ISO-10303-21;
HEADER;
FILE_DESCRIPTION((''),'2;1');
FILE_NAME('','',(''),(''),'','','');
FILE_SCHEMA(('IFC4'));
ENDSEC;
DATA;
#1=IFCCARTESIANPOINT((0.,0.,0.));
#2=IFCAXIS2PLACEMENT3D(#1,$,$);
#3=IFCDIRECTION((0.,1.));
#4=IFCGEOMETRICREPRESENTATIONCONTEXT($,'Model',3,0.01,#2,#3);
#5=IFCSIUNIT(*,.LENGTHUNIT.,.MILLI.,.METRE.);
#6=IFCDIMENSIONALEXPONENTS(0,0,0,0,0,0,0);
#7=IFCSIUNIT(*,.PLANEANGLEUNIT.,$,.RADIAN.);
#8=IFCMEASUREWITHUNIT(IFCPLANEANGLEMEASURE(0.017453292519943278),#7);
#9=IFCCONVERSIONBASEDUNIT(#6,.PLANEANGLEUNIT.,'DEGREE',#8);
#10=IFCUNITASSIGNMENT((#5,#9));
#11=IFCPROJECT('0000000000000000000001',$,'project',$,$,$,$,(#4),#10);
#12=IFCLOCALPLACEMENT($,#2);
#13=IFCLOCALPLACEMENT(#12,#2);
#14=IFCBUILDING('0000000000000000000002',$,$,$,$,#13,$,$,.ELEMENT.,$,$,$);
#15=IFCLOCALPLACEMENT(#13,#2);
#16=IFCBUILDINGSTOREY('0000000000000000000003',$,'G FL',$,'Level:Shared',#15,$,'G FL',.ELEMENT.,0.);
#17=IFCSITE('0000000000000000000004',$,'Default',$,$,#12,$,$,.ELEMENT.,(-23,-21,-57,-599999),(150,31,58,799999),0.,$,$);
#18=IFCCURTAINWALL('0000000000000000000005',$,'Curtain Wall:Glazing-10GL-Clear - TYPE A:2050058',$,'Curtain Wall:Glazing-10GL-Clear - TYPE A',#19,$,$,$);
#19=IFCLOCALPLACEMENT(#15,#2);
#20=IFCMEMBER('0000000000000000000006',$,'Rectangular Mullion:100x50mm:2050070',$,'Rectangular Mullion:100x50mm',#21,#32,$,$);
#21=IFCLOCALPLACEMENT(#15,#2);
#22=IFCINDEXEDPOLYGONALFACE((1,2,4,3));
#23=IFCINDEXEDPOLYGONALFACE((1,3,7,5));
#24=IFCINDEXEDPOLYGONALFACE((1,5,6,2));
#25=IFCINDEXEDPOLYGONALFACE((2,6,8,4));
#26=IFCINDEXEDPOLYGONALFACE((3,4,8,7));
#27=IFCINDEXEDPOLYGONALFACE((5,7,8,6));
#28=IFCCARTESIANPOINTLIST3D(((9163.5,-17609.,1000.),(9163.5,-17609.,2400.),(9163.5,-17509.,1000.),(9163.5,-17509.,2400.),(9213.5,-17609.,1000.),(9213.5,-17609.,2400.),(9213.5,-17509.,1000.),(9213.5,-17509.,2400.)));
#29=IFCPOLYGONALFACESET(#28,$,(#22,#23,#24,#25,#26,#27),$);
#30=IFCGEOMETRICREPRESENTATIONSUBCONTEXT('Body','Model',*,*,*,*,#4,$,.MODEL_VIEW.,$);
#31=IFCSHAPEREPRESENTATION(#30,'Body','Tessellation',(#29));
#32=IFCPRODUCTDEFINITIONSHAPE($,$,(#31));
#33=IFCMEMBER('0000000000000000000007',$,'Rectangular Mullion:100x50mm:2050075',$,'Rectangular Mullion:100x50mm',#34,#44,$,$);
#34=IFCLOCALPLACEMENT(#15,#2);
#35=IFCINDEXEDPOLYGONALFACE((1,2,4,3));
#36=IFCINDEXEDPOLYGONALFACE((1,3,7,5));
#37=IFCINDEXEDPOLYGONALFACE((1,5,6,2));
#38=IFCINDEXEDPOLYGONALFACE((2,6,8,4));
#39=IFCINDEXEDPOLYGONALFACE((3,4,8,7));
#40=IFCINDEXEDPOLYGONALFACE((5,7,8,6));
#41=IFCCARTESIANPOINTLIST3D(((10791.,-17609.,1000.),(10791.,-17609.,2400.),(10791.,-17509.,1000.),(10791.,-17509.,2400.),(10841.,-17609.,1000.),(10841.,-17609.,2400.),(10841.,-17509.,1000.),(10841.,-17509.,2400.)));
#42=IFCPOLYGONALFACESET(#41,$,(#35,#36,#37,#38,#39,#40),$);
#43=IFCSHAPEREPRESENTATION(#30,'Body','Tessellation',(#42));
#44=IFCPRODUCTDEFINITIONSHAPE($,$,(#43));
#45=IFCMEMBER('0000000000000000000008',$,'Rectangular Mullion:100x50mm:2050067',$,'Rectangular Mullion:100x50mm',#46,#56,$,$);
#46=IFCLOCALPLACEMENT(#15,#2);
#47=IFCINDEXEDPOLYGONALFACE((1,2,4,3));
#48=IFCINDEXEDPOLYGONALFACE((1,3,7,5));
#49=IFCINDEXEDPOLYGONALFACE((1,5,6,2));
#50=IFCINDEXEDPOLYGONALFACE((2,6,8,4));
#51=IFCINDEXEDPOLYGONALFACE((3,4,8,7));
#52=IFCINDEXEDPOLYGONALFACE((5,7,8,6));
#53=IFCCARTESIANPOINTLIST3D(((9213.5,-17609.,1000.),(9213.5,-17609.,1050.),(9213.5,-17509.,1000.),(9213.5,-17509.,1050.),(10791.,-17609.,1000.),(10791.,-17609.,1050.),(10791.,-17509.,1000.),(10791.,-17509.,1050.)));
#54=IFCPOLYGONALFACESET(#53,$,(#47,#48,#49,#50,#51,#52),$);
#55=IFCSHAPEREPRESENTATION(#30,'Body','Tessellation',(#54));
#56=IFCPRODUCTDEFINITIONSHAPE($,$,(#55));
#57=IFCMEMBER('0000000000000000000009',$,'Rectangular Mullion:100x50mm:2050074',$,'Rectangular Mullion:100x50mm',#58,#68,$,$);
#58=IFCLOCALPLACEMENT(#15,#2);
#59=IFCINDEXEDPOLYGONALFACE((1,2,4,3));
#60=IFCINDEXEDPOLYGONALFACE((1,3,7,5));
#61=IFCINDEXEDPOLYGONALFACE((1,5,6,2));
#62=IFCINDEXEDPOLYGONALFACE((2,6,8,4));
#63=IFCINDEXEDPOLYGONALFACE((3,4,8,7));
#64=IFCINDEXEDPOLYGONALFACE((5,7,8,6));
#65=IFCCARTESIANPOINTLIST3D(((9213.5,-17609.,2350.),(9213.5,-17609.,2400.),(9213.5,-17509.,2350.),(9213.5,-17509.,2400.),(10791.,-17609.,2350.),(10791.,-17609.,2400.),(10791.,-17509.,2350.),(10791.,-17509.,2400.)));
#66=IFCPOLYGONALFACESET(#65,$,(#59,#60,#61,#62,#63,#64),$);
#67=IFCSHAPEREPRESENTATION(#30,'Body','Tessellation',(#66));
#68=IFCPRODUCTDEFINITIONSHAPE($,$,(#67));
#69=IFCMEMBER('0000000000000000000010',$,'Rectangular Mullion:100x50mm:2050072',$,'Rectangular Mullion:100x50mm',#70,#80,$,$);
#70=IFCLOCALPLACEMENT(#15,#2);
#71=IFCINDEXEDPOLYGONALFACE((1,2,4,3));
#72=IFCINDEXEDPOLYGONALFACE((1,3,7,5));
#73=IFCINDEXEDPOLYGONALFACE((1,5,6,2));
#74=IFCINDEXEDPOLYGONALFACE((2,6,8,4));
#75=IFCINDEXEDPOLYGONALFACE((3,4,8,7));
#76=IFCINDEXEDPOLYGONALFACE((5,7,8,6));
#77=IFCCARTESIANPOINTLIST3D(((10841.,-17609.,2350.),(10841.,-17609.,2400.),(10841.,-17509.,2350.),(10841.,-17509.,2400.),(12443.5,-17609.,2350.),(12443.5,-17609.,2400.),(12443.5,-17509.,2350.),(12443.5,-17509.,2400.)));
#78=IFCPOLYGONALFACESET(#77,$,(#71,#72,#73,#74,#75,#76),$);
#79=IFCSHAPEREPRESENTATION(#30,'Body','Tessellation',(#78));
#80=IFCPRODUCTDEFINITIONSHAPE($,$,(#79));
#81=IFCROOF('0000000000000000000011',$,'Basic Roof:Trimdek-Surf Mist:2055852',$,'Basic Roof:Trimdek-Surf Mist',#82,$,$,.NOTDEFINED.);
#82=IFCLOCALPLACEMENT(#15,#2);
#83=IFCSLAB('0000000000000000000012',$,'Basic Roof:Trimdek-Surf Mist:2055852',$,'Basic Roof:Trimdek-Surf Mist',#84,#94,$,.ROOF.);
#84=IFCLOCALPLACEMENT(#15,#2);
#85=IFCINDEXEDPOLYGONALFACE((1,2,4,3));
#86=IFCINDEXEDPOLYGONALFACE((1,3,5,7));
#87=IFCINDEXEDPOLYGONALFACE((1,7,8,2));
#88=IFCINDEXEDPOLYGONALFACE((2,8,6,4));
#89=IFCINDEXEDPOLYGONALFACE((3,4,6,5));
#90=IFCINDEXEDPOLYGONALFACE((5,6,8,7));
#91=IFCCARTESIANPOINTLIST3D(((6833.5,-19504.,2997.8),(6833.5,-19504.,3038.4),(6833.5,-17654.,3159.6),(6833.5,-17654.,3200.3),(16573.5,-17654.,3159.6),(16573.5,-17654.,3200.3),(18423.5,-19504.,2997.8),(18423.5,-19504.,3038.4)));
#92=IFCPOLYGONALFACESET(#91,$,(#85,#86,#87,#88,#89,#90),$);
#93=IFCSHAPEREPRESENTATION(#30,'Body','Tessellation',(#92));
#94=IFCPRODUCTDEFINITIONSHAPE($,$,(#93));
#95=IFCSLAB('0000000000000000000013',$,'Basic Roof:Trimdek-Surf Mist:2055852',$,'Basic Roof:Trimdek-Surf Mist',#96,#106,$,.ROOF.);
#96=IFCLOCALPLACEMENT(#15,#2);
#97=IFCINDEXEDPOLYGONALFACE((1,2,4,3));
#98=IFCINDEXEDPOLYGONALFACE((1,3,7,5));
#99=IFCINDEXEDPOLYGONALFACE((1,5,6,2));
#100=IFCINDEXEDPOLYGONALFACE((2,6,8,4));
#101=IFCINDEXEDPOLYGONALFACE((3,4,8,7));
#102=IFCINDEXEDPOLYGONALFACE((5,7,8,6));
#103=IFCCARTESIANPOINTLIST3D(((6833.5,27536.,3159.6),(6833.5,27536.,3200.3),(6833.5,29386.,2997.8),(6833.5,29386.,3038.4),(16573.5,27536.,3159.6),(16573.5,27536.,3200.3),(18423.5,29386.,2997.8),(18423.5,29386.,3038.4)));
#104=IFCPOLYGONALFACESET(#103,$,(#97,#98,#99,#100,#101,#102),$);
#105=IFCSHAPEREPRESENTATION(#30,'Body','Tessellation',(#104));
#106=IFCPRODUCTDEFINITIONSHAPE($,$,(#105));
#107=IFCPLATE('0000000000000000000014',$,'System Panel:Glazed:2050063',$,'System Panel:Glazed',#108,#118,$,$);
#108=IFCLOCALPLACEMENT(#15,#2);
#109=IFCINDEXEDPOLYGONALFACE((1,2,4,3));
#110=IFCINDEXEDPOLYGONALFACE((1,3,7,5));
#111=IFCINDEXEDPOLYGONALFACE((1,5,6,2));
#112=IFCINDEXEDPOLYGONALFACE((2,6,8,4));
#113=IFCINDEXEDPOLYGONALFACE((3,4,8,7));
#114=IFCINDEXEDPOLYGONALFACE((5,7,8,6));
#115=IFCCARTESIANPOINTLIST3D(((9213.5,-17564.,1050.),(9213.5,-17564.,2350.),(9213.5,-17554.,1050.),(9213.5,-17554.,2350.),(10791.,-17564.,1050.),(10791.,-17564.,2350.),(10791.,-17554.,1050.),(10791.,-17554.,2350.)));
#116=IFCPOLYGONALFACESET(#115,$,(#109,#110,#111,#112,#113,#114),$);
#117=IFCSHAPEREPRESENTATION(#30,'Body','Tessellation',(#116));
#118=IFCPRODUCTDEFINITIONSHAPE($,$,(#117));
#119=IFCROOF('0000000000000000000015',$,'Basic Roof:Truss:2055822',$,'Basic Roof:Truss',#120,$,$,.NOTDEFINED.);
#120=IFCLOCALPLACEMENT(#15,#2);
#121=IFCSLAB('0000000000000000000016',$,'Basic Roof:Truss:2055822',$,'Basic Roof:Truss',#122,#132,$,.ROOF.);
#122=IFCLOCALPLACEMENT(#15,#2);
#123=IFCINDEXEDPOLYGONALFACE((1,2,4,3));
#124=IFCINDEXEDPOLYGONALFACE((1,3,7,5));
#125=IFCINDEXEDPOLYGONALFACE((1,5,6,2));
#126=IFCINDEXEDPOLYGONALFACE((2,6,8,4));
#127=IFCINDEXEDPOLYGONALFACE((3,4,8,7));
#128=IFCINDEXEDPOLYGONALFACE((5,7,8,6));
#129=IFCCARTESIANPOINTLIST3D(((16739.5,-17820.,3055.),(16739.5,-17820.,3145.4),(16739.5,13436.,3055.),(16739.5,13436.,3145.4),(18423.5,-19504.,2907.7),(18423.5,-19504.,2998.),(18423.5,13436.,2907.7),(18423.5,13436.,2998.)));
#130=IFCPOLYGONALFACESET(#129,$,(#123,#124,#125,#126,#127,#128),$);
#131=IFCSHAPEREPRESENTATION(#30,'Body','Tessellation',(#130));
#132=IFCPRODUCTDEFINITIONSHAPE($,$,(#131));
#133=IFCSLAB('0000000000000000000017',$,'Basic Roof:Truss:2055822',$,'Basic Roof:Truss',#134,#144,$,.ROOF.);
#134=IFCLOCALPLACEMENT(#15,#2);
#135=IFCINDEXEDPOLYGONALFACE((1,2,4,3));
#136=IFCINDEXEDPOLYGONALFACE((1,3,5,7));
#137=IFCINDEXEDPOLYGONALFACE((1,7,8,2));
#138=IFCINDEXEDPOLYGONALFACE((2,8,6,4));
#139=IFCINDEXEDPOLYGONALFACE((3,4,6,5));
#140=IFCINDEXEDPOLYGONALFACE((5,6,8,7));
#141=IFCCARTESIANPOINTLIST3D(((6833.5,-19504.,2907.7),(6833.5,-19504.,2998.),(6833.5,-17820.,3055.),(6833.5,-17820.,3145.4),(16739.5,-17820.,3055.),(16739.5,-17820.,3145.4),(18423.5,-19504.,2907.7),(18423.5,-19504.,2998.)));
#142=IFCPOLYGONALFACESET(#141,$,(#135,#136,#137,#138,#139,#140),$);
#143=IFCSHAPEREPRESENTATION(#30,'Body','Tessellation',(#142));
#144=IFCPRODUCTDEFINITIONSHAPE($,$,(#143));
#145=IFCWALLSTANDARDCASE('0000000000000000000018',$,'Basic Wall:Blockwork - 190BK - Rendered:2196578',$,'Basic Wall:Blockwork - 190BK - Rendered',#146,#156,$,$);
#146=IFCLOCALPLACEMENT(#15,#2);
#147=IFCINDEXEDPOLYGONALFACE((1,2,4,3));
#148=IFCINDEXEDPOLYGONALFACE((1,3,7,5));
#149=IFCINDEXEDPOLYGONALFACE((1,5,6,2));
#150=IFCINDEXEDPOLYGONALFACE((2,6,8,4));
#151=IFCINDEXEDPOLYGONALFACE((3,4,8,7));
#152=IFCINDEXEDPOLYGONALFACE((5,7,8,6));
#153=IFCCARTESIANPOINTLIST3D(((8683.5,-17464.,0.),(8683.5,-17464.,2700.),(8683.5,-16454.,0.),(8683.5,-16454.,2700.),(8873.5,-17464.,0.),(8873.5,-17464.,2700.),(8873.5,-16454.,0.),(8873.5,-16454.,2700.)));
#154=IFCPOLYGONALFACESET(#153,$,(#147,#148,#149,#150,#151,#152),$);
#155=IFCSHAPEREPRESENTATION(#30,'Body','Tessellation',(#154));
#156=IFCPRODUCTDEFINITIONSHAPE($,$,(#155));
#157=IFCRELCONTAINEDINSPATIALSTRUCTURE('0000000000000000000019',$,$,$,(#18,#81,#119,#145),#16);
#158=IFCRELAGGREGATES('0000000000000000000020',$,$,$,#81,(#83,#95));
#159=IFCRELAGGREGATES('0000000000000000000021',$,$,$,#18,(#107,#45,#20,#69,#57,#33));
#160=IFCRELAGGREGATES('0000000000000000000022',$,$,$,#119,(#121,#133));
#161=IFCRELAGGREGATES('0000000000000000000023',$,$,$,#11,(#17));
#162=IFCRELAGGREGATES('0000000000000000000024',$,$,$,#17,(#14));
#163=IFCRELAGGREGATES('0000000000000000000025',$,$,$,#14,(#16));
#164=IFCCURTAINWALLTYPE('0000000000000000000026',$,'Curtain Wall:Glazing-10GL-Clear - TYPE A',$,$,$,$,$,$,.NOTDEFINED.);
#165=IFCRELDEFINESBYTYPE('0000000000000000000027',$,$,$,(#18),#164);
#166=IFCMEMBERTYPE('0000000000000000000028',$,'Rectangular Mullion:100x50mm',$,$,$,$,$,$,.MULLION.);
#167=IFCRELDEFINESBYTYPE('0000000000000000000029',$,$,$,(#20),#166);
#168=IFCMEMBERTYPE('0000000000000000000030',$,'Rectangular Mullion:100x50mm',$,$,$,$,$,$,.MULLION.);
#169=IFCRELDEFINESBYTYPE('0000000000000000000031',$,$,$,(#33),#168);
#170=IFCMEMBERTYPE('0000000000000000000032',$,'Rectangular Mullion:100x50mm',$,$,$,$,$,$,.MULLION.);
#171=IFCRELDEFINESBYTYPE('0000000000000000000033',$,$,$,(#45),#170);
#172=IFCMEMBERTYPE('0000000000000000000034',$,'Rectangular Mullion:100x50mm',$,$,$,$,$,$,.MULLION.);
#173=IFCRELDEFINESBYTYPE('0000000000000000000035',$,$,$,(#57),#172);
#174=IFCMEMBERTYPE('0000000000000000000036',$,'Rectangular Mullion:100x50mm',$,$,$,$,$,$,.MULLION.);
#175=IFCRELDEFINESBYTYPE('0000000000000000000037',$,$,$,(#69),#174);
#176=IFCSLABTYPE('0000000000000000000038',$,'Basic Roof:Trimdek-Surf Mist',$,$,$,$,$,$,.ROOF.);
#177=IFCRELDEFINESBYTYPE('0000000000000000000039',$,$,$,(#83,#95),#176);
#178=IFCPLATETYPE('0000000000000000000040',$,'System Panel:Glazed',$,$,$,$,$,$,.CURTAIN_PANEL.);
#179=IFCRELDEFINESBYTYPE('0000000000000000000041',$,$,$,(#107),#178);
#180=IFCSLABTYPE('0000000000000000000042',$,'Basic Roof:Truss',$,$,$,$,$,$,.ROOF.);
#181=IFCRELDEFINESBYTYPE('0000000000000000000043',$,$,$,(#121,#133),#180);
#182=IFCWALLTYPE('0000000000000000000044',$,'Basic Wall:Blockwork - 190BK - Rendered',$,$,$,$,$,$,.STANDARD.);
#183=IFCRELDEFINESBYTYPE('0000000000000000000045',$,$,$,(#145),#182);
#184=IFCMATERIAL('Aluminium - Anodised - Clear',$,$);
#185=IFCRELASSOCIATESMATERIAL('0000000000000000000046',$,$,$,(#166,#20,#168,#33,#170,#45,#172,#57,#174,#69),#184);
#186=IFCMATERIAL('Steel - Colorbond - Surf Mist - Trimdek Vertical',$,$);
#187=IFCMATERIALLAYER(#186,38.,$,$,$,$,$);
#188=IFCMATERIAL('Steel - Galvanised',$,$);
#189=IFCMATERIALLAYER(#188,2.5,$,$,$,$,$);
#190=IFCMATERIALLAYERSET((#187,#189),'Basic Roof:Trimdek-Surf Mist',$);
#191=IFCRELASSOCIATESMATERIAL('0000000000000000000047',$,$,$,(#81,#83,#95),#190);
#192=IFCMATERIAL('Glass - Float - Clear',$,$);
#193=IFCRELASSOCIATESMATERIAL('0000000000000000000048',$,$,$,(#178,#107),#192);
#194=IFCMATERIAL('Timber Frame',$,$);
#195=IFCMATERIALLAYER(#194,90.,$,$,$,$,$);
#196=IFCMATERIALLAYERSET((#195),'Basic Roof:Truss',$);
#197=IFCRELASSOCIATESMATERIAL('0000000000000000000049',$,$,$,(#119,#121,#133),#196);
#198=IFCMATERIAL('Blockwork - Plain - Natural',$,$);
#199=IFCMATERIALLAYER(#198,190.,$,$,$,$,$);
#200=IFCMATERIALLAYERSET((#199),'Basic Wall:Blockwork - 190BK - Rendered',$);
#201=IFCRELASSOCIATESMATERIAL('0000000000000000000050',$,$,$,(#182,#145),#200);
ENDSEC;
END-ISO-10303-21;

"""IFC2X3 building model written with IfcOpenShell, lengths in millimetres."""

from ifc_helpers import new_model, entity, si_unit, converted_unit, direction, frame, frame_2d, origin, origin_2d_with_axis, place, context, subcontext, project, spatial, polyline, rectangle, outline, extrude, source, transform, mapped, material, layer, layer_set, layer_usage, type_object, type_shapes, element, aggregate, save


model = new_model("IFC2X3")

# Units and contexts
model_context = context("Model", 3, precision=0.01, world=origin(), true_north=direction((0.0, 1.0)))
body_context = subcontext(model_context, "Body", "Model", "MODEL_VIEW")
ifc_project = project(units=[si_unit("LENGTHUNIT", "METRE", prefix="MILLI"), converted_unit("PLANEANGLEUNIT", "DEGREE", entity("IfcPlaneAngleMeasure", 0.017453292519943278), si_unit("PLANEANGLEUNIT", "RADIAN"), dimensions=[0, 0, 0, 0, 0, 0, 0])], contexts=[model_context])

# Site, building, storey
site_placement = place(None, origin())
site = spatial("IfcSite", under=ifc_project, at=site_placement, Name="Default", CompositionType="ELEMENT", RefLatitude=(-23, -21, -57, -599999), RefLongitude=(150, 31, 58, 799999), RefElevation=0.0)
building_placement = place(site_placement, origin())
building = spatial("IfcBuilding", under=site, at=building_placement, CompositionType="ELEMENT")
storey_placement = place(building_placement, origin())
storey = spatial("IfcBuildingStorey", under=building, at=storey_placement, Name="G FL", ObjectType="Level:Shared", LongName="G FL", CompositionType="ELEMENT", Elevation=0.0)

# Curtain wall, members
curtain_wall_type = type_object("IfcCurtainWallType", Name="Curtain Wall:Glazing-10GL-Clear - TYPE A", PredefinedType="NOTDEFINED")
curtain_wall_placement = place(storey_placement, origin())
curtain_wall = element("IfcCurtainWall", 1, at=curtain_wall_placement, inside=storey, type_object=curtain_wall_type, Name="Curtain Wall:Glazing-10GL-Clear - TYPE A:2050058", ObjectType="Curtain Wall:Glazing-10GL-Clear - TYPE A")
ifc_material_1 = material(Name="Aluminium - Anodised - Clear")
member_type_1 = type_object("IfcMemberType", Name="Rectangular Mullion:100x50mm", PredefinedType="MULLION", material=ifc_material_1)
shared_shape_1 = source(origin(), body_context, "Body", "SweptSolid", [
    extrude(rectangle(XDim=50.0, YDim=100.0, at=frame_2d((0.0, 0.0), x_axis=(1.0, 0.0))), frame((-25.0, 0.0, -1400.0), z_axis=(0.0, 0.0, 1.0), x_axis=(-1.0, 0.0, 0.0)), (0.0, 0.0, 1.0), 1400.0),
])
type_shapes(member_type_1, [shared_shape_1])
member_1_placement = place(curtain_wall_placement, frame((9163.5, -17559.0, 1000.0), z_axis=(0.0, 0.0, -1.0), x_axis=(-1.0, 0.0, 0.0)))
member_1 = element("IfcMember", 2, at=member_1_placement, type_object=member_type_1, material=ifc_material_1, Name="Rectangular Mullion:100x50mm:2050070", ObjectType="Rectangular Mullion:100x50mm", context=body_context, shape_type="MappedRepresentation", body=[
    mapped(shared_shape_1, transform((0.0, 0.0, 0.0), scale=1.0)),
])
member_type_2 = type_object("IfcMemberType", Name="Rectangular Mullion:100x50mm", PredefinedType="MULLION", material=ifc_material_1)
shared_shape_2 = source(origin(), body_context, "Body", "SweptSolid", [
    extrude(rectangle(XDim=50.0, YDim=100.0, at=frame_2d((0.0, 0.0), x_axis=(1.0, 0.0))), frame((0.0, 0.0, -1400.0), z_axis=(0.0, 0.0, 1.0), x_axis=(-1.0, 0.0, 0.0)), (0.0, 0.0, 1.0), 1400.0),
])
type_shapes(member_type_2, [shared_shape_2])
member_2_placement = place(curtain_wall_placement, frame((10816.0, -17559.0, 1000.0), z_axis=(0.0, 0.0, -1.0), x_axis=(-1.0, 0.0, 0.0)))
member_2 = element("IfcMember", 3, at=member_2_placement, type_object=member_type_2, material=ifc_material_1, Name="Rectangular Mullion:100x50mm:2050075", ObjectType="Rectangular Mullion:100x50mm", context=body_context, shape_type="MappedRepresentation", body=[
    mapped(shared_shape_2, transform((0.0, 0.0, 0.0), scale=1.0)),
])
member_type_3 = type_object("IfcMemberType", Name="Rectangular Mullion:100x50mm", PredefinedType="MULLION", material=ifc_material_1)
shared_shape_3 = source(origin(), body_context, "Body", "SweptSolid", [
    extrude(rectangle(XDim=50.0, YDim=100.0, at=frame_2d((0.0, 0.0), x_axis=(1.0, 0.0))), frame((-25.0, 0.0, -1577.5), z_axis=(0.0, 0.0, 1.0), x_axis=(-1.0, 0.0, 0.0)), (0.0, 0.0, 1.0), 1577.5),
])
type_shapes(member_type_3, [shared_shape_3])
member_3_placement = place(curtain_wall_placement, frame((10791.0, -17559.0, 1000.0), z_axis=(1.0, 0.0, 0.0), x_axis=(0.0, 0.0, -1.0)))
member_3 = element("IfcMember", 4, at=member_3_placement, type_object=member_type_3, material=ifc_material_1, Name="Rectangular Mullion:100x50mm:2050067", ObjectType="Rectangular Mullion:100x50mm", context=body_context, shape_type="MappedRepresentation", body=[
    mapped(shared_shape_3, transform((0.0, 0.0, 0.0), scale=1.0)),
])
member_type_4 = type_object("IfcMemberType", Name="Rectangular Mullion:100x50mm", PredefinedType="MULLION", material=ifc_material_1)
shared_shape_4 = source(origin(), body_context, "Body", "SweptSolid", [
    extrude(rectangle(XDim=50.0, YDim=100.0, at=origin_2d_with_axis()), frame((-25.0, 0.0, -1577.5), z_axis=(0.0, 0.0, 1.0), x_axis=(-1.0, 0.0, 0.0)), (0.0, 0.0, 1.0), 1577.5),
])
type_shapes(member_type_4, [shared_shape_4])
member_4_placement = place(curtain_wall_placement, frame((9213.5, -17559.0, 2400.0), z_axis=(-1.0, 0.0, 0.0), x_axis=(0.0, 0.0, 1.0)))
member_4 = element("IfcMember", 5, at=member_4_placement, type_object=member_type_4, material=ifc_material_1, Name="Rectangular Mullion:100x50mm:2050074", ObjectType="Rectangular Mullion:100x50mm", context=body_context, shape_type="MappedRepresentation", body=[
    mapped(shared_shape_4, transform((0.0, 0.0, 0.0), scale=1.0)),
])
member_type_5 = type_object("IfcMemberType", Name="Rectangular Mullion:100x50mm", PredefinedType="MULLION", material=ifc_material_1)
shared_shape_5 = source(origin(), body_context, "Body", "SweptSolid", [
    extrude(rectangle(XDim=50.0, YDim=100.0, at=origin_2d_with_axis()), frame((-25.0, 0.0, -1602.5), z_axis=(0.0, 0.0, 1.0), x_axis=(-1.0, 0.0, 0.0)), (0.0, 0.0, 1.0), 1602.5),
])
type_shapes(member_type_5, [shared_shape_5])
member_5_placement = place(curtain_wall_placement, frame((10841.0, -17559.0, 2400.0), z_axis=(-1.0, 0.0, 0.0), x_axis=(0.0, 0.0, 1.0)))
member_5 = element("IfcMember", 6, at=member_5_placement, type_object=member_type_5, material=ifc_material_1, Name="Rectangular Mullion:100x50mm:2050072", ObjectType="Rectangular Mullion:100x50mm", context=body_context, shape_type="MappedRepresentation", body=[
    mapped(shared_shape_5, transform((0.0, 0.0, 0.0), scale=1.0)),
])

# Roof, slabs
ifc_material_2 = material(Name="Steel - Colorbond - Surf Mist - Trimdek Vertical")
ifc_layer_1 = layer(ifc_material_2, 38.0)
ifc_material_3 = material(Name="Steel - Galvanised")
ifc_layer_2 = layer(ifc_material_3, 2.5)
ifc_layer_set_1 = layer_set([ifc_layer_1, ifc_layer_2], Name="Basic Roof:Trimdek-Surf Mist")
roof_1_placement = place(storey_placement, frame((6833.5, -19504.0, 2997.8)))
roof_1 = element("IfcRoof", 7, at=roof_1_placement, inside=storey, material=ifc_layer_set_1, Name="Basic Roof:Trimdek-Surf Mist:2055852", ObjectType="Basic Roof:Trimdek-Surf Mist", ShapeType="NOTDEFINED")
slab_type_1 = type_object("IfcSlabType", Name="Basic Roof:Trimdek-Surf Mist", PredefinedType="ROOF")
slab_1_placement = place(roof_1_placement, origin())
slab_1 = element("IfcSlab", 8, at=slab_1_placement, type_object=slab_type_1, material=ifc_layer_set_1, Name="Basic Roof:Trimdek-Surf Mist:2055852", ObjectType="Basic Roof:Trimdek-Surf Mist", PredefinedType="ROOF", context=body_context, shape_type="SweptSolid", body=[
    extrude(outline(polyline([(-5795.0, 928.5), (-5795.0, -928.5), (5795.0, -928.5), (3945.0, 928.5), (-5795.0, 928.5)])), frame((5795.0, 925.0, 80.9), z_axis=(0.0, -0.087156, 0.996195), x_axis=(1.0, 0.0, 0.0)), (0.0, 0.087156, 0.996195), 40.7),
])
slab_2_placement = place(roof_1_placement, origin())
slab_2 = element("IfcSlab", 9, at=slab_2_placement, type_object=slab_type_1, material=ifc_layer_set_1, Name="Basic Roof:Trimdek-Surf Mist:2055852", ObjectType="Basic Roof:Trimdek-Surf Mist", PredefinedType="ROOF", context=body_context, shape_type="SweptSolid", body=[
    extrude(outline(polyline([(5795.0, 928.5), (-5795.0, 928.5), (-5795.0, -928.5), (3945.0, -928.5), (5795.0, 928.5)])), frame((5795.0, 47965.0, 80.9), z_axis=(0.0, 0.087156, 0.996195), x_axis=(1.0, 0.0, 0.0)), (0.0, -0.087156, 0.996195), 40.7),
])
aggregate(roof_1, [slab_1, slab_2])

# Plate
ifc_material_4 = material(Name="Glass - Float - Clear")
plate_type = type_object("IfcPlateType", Name="System Panel:Glazed", PredefinedType="CURTAIN_PANEL", material=ifc_material_4)
shared_shape_6 = source(origin(), body_context, "Body", "SweptSolid", [
    extrude(rectangle(XDim=10.0, YDim=1577.5, at=origin_2d_with_axis()), frame((0.0, 0.0, 0.0), z_axis=(0.0, 0.0, 1.0), x_axis=(0.0, 1.0, 0.0)), (0.0, 0.0, 1.0), 1300.0),
])
type_shapes(plate_type, [shared_shape_6])
plate_placement = place(curtain_wall_placement, frame((10002.3, -17559.0, 1050.0), z_axis=(0.0, 0.0, 1.0), x_axis=(-1.0, 0.0, 0.0)))
plate = element("IfcPlate", 10, at=plate_placement, type_object=plate_type, material=ifc_material_4, Name="System Panel:Glazed:2050063", ObjectType="System Panel:Glazed", context=body_context, shape_type="MappedRepresentation", body=[
    mapped(shared_shape_6, transform((0.0, 0.0, 0.0), scale=1.0)),
])
aggregate(curtain_wall, [plate, member_3, member_1, member_5, member_4, member_2])

# Roof, slabs
ifc_material_5 = material(Name="Timber Frame")
ifc_layer_3 = layer(ifc_material_5, 90.0)
ifc_layer_set_2 = layer_set([ifc_layer_3], Name="Basic Roof:Truss")
roof_2_placement = place(storey_placement, frame((6833.5, -19504.0, 2907.7)))
roof_2 = element("IfcRoof", 11, at=roof_2_placement, inside=storey, material=ifc_layer_set_2, Name="Basic Roof:Truss:2055822", ObjectType="Basic Roof:Truss", ShapeType="NOTDEFINED")
slab_type_2 = type_object("IfcSlabType", Name="Basic Roof:Truss", PredefinedType="ROOF")
slab_3_placement = place(roof_2_placement, origin())
slab_3 = element("IfcSlab", 12, at=slab_3_placement, type_object=slab_type_2, material=ifc_layer_set_2, Name="Basic Roof:Truss:2055822", ObjectType="Basic Roof:Truss", PredefinedType="ROOF", context=body_context, shape_type="SweptSolid", body=[
    extrude(outline(polyline([(-845.2, -14786.0), (845.2, -16470.0), (845.2, 16470.0), (-845.2, 16470.0), (-845.2, -14786.0)])), frame((10748.0, 16470.0, 73.7), z_axis=(0.087156, 0.0, 0.996195), x_axis=(0.996195, 0.0, -0.087156)), (-0.087156, 0.0, 0.996195), 90.3),
])
slab_4_placement = place(roof_2_placement, origin())
slab_4 = element("IfcSlab", 13, at=slab_4_placement, type_object=slab_type_2, material=ifc_layer_set_2, Name="Basic Roof:Truss:2055822", ObjectType="Basic Roof:Truss", PredefinedType="ROOF", context=body_context, shape_type="SweptSolid", body=[
    extrude(outline(polyline([(-5795.0, 845.2), (-5795.0, -845.2), (5795.0, -845.2), (4111.0, 845.2), (-5795.0, 845.2)])), frame((5795.0, 842.0, 73.7), z_axis=(0.0, -0.087156, 0.996195), x_axis=(1.0, 0.0, 0.0)), (0.0, 0.087156, 0.996195), 90.3),
])
aggregate(roof_2, [slab_3, slab_4])

# Wall
ifc_material_6 = material(Name="Blockwork - Plain - Natural")
ifc_layer_4 = layer(ifc_material_6, 190.0)
ifc_layer_set_3 = layer_set([ifc_layer_4], Name="Basic Wall:Blockwork - 190BK - Rendered")
ifc_layer_usage_1 = layer_usage(ifc_layer_set_3, "AXIS2", "NEGATIVE", 95.0)
wall_type_1 = type_object("IfcWallType", Name="Basic Wall:Blockwork - 190BK - Rendered", PredefinedType="STANDARD", material=ifc_layer_set_3)
wall_1_placement = place(storey_placement, frame((8778.5, -17464.0, 0.0), z_axis=(0.0, 0.0, 1.0), x_axis=(0.0, 1.0, 0.0)))
element("IfcWallStandardCase", 14, at=wall_1_placement, inside=storey, type_object=wall_type_1, material=ifc_layer_usage_1, Name="Basic Wall:Blockwork - 190BK - Rendered:2196578", ObjectType="Basic Wall:Blockwork - 190BK - Rendered", context=body_context, shape_type="SweptSolid", body=[
    extrude(rectangle(XDim=1010.0, YDim=190.0, at=frame_2d((505.0, 0.0), x_axis=(-1.0, 0.0))), origin(), (0.0, 0.0, 1.0), 2700.0),
])

save(model, "model.ifc")
